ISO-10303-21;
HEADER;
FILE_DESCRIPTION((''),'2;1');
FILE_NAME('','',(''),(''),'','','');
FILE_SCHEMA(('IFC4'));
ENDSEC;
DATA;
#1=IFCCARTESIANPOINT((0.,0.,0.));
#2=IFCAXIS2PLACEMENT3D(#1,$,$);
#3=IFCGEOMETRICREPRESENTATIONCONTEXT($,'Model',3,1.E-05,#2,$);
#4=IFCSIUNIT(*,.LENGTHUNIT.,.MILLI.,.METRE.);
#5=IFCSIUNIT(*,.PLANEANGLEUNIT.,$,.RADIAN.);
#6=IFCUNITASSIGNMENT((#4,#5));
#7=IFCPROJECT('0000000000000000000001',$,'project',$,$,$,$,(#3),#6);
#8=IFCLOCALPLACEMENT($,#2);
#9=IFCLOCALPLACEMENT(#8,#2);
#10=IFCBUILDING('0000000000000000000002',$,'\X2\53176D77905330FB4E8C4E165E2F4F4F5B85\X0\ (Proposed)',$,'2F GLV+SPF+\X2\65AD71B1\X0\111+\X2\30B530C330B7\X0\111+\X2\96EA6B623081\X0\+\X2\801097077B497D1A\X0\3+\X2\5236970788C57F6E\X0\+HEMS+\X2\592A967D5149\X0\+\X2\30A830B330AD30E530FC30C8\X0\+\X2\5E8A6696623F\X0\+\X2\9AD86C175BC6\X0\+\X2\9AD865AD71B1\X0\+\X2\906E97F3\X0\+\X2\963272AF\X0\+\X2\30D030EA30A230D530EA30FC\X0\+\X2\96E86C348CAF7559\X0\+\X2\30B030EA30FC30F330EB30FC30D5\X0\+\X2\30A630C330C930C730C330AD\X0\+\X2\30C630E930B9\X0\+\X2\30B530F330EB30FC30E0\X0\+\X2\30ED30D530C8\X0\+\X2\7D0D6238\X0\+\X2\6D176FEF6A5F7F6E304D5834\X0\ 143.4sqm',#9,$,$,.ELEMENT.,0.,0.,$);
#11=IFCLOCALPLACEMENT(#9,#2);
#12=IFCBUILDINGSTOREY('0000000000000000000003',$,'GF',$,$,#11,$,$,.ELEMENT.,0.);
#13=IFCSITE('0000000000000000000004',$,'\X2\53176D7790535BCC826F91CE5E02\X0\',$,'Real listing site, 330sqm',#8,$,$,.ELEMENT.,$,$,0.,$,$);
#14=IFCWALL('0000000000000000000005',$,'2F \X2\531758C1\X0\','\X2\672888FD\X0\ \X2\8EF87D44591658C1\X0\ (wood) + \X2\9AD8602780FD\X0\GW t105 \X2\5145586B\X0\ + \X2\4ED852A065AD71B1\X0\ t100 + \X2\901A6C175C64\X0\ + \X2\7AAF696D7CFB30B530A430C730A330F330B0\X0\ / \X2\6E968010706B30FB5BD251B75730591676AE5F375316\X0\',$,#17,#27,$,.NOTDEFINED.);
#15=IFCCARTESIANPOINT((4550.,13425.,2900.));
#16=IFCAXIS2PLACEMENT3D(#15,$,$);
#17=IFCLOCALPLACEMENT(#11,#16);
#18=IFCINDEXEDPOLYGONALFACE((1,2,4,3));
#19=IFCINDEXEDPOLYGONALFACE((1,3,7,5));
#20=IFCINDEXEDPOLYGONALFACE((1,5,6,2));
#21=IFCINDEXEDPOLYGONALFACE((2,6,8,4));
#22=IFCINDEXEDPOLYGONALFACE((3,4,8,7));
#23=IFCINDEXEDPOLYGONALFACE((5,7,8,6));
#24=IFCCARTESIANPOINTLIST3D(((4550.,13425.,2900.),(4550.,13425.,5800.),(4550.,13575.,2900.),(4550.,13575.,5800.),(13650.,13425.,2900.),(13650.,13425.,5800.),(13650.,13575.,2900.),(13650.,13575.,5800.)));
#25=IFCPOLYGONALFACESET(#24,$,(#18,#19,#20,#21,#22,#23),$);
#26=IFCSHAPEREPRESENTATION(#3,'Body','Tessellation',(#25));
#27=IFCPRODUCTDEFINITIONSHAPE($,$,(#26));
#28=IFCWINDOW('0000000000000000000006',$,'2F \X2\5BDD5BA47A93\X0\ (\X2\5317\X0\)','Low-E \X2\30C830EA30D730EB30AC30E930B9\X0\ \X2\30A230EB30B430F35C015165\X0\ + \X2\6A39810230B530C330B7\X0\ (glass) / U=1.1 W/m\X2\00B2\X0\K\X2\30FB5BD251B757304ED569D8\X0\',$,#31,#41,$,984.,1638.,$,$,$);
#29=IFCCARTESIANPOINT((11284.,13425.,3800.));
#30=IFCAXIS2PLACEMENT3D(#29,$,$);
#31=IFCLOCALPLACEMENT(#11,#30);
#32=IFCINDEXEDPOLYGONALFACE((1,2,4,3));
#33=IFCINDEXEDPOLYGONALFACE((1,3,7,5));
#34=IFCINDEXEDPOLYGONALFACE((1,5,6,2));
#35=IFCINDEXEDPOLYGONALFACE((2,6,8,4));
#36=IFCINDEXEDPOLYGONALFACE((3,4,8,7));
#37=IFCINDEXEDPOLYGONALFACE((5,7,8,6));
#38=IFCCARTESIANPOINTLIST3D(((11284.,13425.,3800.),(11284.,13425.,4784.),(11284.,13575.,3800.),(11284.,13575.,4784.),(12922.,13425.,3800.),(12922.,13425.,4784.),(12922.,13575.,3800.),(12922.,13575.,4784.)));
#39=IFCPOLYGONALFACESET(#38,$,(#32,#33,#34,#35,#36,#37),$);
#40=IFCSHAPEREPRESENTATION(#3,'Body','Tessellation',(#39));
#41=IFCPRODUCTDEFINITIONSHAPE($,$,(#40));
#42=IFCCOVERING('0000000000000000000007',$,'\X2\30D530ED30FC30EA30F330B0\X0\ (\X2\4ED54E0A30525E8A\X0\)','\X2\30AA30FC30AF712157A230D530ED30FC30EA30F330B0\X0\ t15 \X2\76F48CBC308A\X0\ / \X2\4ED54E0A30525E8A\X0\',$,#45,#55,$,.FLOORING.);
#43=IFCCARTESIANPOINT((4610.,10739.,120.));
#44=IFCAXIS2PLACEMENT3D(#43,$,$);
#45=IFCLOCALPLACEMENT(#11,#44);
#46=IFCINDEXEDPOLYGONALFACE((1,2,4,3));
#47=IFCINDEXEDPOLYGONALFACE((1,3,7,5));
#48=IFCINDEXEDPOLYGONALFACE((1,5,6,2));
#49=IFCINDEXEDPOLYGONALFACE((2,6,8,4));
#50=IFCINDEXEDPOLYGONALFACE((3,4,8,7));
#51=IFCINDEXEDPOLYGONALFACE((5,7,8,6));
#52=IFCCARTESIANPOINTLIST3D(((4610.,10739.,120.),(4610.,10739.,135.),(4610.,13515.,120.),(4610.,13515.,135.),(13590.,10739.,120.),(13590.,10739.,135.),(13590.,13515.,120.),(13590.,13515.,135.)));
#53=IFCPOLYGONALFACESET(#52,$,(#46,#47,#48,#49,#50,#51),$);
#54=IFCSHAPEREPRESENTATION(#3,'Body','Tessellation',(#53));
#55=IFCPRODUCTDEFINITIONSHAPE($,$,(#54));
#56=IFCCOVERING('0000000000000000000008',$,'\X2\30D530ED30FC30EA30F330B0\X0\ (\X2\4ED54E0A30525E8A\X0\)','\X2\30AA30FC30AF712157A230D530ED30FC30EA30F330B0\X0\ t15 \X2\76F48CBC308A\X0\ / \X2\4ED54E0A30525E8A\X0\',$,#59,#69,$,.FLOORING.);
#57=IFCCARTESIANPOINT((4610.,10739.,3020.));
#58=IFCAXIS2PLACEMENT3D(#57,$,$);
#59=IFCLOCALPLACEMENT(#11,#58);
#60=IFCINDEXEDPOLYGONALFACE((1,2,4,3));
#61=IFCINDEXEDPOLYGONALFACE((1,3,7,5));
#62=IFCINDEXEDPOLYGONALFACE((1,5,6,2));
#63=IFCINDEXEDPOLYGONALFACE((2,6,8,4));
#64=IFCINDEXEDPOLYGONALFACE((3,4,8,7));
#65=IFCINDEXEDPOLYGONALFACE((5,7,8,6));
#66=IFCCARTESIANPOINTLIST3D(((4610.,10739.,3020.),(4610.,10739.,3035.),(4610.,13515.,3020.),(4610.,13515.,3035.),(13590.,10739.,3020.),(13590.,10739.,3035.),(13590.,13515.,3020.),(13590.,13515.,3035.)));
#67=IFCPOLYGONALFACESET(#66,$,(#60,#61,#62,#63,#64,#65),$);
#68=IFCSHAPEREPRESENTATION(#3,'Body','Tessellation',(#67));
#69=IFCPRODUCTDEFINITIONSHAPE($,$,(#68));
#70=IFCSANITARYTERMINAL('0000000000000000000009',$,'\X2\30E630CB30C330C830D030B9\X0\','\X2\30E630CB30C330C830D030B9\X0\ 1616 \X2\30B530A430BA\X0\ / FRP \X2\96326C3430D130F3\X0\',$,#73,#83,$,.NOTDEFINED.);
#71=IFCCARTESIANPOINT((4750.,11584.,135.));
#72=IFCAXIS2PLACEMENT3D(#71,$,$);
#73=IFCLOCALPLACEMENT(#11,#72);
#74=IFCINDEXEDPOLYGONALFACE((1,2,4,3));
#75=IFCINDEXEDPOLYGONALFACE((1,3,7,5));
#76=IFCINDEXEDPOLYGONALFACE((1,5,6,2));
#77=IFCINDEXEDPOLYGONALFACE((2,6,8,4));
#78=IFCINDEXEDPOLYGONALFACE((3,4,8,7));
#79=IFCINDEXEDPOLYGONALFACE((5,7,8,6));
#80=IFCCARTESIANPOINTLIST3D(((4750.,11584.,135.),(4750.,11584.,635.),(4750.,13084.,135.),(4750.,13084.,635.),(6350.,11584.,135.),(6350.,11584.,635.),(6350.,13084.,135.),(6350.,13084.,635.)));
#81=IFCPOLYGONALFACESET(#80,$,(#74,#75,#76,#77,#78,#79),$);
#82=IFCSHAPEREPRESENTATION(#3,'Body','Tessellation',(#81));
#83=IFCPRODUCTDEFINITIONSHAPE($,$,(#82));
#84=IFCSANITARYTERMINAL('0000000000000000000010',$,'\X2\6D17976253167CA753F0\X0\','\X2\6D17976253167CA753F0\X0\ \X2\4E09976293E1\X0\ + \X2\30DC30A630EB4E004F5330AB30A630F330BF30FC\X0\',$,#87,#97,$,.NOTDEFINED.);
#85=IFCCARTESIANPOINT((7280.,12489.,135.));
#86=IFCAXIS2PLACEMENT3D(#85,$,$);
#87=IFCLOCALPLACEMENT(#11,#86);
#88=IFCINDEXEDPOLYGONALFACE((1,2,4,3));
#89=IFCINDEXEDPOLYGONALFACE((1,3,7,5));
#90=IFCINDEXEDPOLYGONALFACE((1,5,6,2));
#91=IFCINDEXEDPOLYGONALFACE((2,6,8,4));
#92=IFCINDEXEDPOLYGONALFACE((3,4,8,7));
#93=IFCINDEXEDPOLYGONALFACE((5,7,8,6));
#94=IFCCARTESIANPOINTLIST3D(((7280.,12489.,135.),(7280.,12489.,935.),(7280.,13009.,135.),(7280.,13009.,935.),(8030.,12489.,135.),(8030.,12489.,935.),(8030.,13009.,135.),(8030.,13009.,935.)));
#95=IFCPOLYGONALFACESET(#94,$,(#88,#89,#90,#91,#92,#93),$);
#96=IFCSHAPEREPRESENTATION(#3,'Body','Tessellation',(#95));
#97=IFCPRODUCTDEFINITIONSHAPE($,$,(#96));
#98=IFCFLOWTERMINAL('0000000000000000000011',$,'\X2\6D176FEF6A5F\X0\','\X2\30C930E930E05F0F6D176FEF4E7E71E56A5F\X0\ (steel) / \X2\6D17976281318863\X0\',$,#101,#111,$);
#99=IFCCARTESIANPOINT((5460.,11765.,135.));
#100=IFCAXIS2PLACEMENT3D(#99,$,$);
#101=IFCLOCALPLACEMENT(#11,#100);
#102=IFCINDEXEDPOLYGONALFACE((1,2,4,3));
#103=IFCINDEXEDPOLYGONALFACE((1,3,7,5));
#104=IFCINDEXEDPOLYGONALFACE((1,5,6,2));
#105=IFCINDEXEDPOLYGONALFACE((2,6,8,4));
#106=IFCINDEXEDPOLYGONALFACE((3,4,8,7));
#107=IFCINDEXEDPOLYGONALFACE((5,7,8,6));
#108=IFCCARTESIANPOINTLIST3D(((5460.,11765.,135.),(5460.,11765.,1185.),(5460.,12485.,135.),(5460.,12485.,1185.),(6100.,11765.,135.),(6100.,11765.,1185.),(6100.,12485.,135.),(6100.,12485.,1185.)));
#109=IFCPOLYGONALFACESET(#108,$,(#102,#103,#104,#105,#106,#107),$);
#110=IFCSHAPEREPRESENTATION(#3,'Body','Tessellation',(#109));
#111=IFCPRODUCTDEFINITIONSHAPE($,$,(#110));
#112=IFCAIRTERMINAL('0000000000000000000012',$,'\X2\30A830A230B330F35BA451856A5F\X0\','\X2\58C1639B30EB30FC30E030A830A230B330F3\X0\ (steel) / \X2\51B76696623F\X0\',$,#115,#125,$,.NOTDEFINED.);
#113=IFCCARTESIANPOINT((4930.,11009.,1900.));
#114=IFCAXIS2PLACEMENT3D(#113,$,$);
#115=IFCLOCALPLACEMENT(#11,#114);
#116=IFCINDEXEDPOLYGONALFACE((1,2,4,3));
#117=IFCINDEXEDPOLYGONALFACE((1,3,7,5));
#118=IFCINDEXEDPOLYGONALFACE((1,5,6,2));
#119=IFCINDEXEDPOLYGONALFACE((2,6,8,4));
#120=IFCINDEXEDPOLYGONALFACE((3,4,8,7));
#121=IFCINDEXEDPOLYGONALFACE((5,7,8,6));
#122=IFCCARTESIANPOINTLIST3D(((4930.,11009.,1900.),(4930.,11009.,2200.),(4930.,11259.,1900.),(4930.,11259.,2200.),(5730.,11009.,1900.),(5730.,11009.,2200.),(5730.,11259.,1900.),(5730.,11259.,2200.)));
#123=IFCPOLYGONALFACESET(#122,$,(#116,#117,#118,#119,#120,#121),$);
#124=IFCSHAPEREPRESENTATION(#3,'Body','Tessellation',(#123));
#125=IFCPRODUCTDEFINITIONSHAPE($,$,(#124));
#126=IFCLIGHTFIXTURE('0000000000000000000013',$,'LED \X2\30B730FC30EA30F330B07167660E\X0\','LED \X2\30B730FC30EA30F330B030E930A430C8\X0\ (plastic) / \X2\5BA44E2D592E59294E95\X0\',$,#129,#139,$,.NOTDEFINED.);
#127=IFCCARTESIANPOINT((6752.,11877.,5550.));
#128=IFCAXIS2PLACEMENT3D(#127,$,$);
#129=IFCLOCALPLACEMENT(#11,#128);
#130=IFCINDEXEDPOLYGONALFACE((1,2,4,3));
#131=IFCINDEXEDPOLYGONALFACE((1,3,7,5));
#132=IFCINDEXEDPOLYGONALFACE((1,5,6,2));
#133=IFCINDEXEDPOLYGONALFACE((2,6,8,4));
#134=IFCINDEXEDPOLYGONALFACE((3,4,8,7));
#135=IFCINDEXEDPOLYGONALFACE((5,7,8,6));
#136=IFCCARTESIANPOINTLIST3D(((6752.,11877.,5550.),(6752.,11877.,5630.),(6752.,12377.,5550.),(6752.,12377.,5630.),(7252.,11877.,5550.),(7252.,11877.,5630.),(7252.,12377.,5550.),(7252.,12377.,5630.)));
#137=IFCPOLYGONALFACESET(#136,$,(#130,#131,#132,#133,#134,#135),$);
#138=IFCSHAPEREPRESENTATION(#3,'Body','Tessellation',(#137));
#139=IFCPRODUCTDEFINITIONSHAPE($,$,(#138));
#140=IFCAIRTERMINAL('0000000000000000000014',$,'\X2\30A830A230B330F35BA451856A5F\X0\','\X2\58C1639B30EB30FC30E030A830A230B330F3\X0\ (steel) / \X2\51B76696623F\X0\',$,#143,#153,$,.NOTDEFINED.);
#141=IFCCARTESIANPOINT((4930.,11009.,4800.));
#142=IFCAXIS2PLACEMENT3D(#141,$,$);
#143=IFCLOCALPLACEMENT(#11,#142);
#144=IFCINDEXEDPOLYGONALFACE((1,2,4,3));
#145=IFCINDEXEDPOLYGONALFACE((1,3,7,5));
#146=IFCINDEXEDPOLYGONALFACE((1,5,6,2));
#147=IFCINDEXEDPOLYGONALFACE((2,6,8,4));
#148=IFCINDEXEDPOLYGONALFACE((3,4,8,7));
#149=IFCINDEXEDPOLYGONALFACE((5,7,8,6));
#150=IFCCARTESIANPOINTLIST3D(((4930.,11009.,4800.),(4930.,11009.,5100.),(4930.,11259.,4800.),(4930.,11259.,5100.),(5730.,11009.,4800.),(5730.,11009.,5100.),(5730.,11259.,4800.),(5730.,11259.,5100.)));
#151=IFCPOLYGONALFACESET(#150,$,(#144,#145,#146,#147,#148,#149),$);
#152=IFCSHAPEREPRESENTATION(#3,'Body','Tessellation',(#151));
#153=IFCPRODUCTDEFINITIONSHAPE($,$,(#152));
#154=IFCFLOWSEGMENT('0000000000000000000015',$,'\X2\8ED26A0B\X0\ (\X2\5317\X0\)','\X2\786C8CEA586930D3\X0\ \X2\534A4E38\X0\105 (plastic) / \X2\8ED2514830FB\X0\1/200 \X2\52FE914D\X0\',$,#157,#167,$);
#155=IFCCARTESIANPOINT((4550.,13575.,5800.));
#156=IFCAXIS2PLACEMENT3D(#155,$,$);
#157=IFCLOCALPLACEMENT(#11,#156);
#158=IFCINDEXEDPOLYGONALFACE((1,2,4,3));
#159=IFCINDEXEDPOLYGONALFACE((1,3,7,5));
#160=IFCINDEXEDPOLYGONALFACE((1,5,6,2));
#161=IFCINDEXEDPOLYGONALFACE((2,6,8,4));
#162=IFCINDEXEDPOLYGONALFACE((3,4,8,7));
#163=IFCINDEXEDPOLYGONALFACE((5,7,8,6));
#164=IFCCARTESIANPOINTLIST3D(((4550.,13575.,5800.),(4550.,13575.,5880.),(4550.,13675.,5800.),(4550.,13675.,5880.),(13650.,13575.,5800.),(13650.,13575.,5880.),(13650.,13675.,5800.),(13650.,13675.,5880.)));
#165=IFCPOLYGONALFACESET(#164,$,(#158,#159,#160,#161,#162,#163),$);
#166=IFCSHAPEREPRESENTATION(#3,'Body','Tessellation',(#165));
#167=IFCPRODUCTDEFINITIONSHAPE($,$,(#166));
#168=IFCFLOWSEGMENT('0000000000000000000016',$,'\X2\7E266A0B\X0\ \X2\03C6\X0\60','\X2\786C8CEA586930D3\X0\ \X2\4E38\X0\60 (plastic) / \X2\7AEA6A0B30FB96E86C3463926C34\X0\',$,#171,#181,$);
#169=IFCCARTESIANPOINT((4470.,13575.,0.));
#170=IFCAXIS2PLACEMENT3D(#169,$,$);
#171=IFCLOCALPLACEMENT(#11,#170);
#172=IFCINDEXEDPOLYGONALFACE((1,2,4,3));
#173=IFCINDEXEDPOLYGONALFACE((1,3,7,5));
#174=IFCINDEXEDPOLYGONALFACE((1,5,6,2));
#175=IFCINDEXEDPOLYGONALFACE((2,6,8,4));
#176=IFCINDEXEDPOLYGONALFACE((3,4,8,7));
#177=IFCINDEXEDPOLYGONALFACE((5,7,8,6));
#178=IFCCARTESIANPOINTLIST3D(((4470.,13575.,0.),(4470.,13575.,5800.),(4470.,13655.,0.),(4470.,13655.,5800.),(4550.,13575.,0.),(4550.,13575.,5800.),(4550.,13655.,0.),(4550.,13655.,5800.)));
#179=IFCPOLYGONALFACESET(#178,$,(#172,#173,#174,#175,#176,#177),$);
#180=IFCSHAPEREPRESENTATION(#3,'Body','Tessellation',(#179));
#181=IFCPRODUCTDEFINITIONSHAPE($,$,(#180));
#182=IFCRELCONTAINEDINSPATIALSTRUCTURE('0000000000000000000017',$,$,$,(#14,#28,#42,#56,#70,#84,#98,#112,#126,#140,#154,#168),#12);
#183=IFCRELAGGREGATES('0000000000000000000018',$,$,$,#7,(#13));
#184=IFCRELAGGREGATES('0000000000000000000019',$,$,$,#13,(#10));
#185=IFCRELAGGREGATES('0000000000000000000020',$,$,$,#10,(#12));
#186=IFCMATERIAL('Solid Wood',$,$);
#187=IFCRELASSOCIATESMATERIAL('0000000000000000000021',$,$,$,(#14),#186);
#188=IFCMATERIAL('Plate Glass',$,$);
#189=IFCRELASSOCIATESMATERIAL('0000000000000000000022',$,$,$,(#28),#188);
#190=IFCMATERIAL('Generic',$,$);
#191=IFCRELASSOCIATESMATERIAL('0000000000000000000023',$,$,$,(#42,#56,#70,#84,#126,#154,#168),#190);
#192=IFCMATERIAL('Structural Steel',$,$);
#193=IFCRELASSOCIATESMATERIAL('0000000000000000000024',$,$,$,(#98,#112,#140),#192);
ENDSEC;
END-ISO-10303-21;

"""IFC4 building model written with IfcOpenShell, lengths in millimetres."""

from ifc_helpers import new_model, si_unit, frame, frame_2d, origin, place, context, project, spatial, rectangle, extrude, material, element, fill, save


model = new_model("IFC4")

# Units and contexts
model_context = context("Model", 3, precision=1e-05, world=origin())
ifc_project = project(units=[si_unit("LENGTHUNIT", "METRE", prefix="MILLI"), si_unit("PLANEANGLEUNIT", "RADIAN")], contexts=[model_context])

# Site, building, storey
site_placement = place(None, origin())
site = spatial("IfcSite", under=ifc_project, at=site_placement, Name="北海道富良野市", ObjectType="Real listing site, 330sqm", CompositionType="ELEMENT", RefElevation=0.0)
building_placement = place(site_placement, origin())
building = spatial("IfcBuilding", under=site, at=building_placement, Name="北海道・二世帯住宅 (Proposed)", ObjectType="2F GLV+SPF+断熱111+サッシ111+雪止め+耐震等級3+制震装置+HEMS+太陽光+エコキュート+床暖房+高気密+高断熱+遮音+防犯+バリアフリー+雨水貯留+グリーンルーフ+ウッドデッキ+テラス+サンルーム+ロフト+納戸+洗濯機置き場 143.4sqm", CompositionType="ELEMENT", ElevationOfRefHeight=0.0, ElevationOfTerrain=0.0)
storey_placement = place(building_placement, origin())
storey = spatial("IfcBuildingStorey", under=building, at=storey_placement, Name="GF", CompositionType="ELEMENT", Elevation=0.0)

# Shared definitions
ifc_material_1 = material(Name="Solid Wood")

# Shared definitions
ifc_material_2 = material(Name="Plate Glass")

# Wall, opening, window
wall_1_placement = place(storey_placement, frame((4550.0, 13425.0, 2900.0)))
wall_1 = element("IfcWall", 1, at=wall_1_placement, inside=storey, material=ifc_material_1, Name="2F 北壁", Description="木製 軸組外壁 (wood) + 高性能GW t105 充填 + 付加断熱 t100 + 通気層 + 窯業系サイディング / 準耐火・寒冷地外皮強化", PredefinedType="NOTDEFINED", context=model_context, shape_type="SweptSolid", body=[
    extrude(rectangle(XDim=9100.0, YDim=150.0, at=frame_2d((4550.0, 75.0))), frame((4550.0, 13425.0, 2900.0)), (0.0, 0.0, 1.0), 2900.0),
])
opening_1_placement = place(storey_placement, frame((11284.0, 13425.0, 3800.0)))
opening_1 = element("IfcOpeningElement", 2, at=opening_1_placement, cuts=wall_1, PredefinedType="NOTDEFINED", context=model_context, shape_type="SweptSolid", body=[
    extrude(rectangle(XDim=1638.0, YDim=150.0, at=frame_2d((819.0, 75.0))), frame((11284.0, 13425.0, 3800.0)), (0.0, 0.0, 1.0), 984.0),
])
window_1_placement = place(storey_placement, frame((11284.0, 13425.0, 3800.0)))
window_1 = element("IfcWindow", 3, at=window_1_placement, inside=storey, material=ifc_material_2, Name="2F 寝室窓 (北)", Description="Low-E トリプルガラス アルゴン封入 + 樹脂サッシ (glass) / U=1.1 W/m²K・寒冷地仕様", OverallHeight=984.0, OverallWidth=1638.0, context=model_context, shape_type="SweptSolid", body=[
    extrude(rectangle(XDim=1638.0, YDim=150.0, at=frame_2d((819.0, 75.0))), frame((11284.0, 13425.0, 3800.0)), (0.0, 0.0, 1.0), 984.0),
])
fill(opening_1, window_1)

# Coverings
ifc_material_3 = material(Name="Generic")
covering_1_placement = place(storey_placement, frame((4610.0, 10739.0, 120.0)))
element("IfcCovering", 4, at=covering_1_placement, inside=storey, material=ifc_material_3, Name="フローリング (仕上げ床)", Description="オーク無垢フローリング t15 直貼り / 仕上げ床", PredefinedType="FLOORING", context=model_context, shape_type="SweptSolid", body=[
    extrude(rectangle(XDim=8980.0, YDim=2776.0, at=frame_2d((4490.0, 1388.0))), frame((4610.0, 10739.0, 120.0)), (0.0, 0.0, 1.0), 15.0),
])
covering_2_placement = place(storey_placement, frame((4610.0, 10739.0, 3020.0)))
element("IfcCovering", 5, at=covering_2_placement, inside=storey, material=ifc_material_3, Name="フローリング (仕上げ床)", Description="オーク無垢フローリング t15 直貼り / 仕上げ床", PredefinedType="FLOORING", context=model_context, shape_type="SweptSolid", body=[
    extrude(rectangle(XDim=8980.0, YDim=2776.0, at=frame_2d((4490.0, 1388.0))), frame((4610.0, 10739.0, 3020.0)), (0.0, 0.0, 1.0), 15.0),
])

# Sanitary terminals
sanitary_terminal_1_placement = place(storey_placement, frame((4750.0, 11584.0, 135.0)))
element("IfcSanitaryTerminal", 6, at=sanitary_terminal_1_placement, inside=storey, material=ifc_material_3, Name="ユニットバス", Description="ユニットバス 1616 サイズ / FRP 防水パン", PredefinedType="NOTDEFINED", context=model_context, shape_type="SweptSolid", body=[
    extrude(rectangle(XDim=1600.0, YDim=1500.0, at=frame_2d((800.0, 750.0))), frame((4750.0, 11584.0, 135.0)), (0.0, 0.0, 1.0), 500.0),
])
sanitary_terminal_2_placement = place(storey_placement, frame((7280.0, 12489.0, 135.0)))
element("IfcSanitaryTerminal", 7, at=sanitary_terminal_2_placement, inside=storey, material=ifc_material_3, Name="洗面化粧台", Description="洗面化粧台 三面鏡 + ボウル一体カウンター", PredefinedType="NOTDEFINED", context=model_context, shape_type="SweptSolid", body=[
    extrude(rectangle(XDim=750.0, YDim=520.0, at=frame_2d((375.0, 260.0))), frame((7280.0, 12489.0, 135.0)), (0.0, 0.0, 1.0), 800.0),
])

# Flow terminal
ifc_material_4 = material(Name="Structural Steel")
flow_terminal_placement = place(storey_placement, frame((5460.0, 11765.0, 135.0)))
element("IfcFlowTerminal", 8, at=flow_terminal_placement, inside=storey, material=ifc_material_4, Name="洗濯機", Description="ドラム式洗濯乾燥機 (steel) / 洗面脱衣", context=model_context, shape_type="SweptSolid", body=[
    extrude(rectangle(XDim=640.0, YDim=720.0, at=frame_2d((320.0, 360.0))), frame((5460.0, 11765.0, 135.0)), (0.0, 0.0, 1.0), 1050.0),
])

# Air terminal
air_terminal_1_placement = place(storey_placement, frame((4930.0, 11009.0, 1900.0)))
element("IfcAirTerminal", 9, at=air_terminal_1_placement, inside=storey, material=ifc_material_4, Name="エアコン室内機", Description="壁掛ルームエアコン (steel) / 冷暖房", PredefinedType="NOTDEFINED", context=model_context, shape_type="SweptSolid", body=[
    extrude(rectangle(XDim=800.0, YDim=250.0, at=frame_2d((400.0, 125.0))), frame((4930.0, 11009.0, 1900.0)), (0.0, 0.0, 1.0), 300.0),
])

# Light fixture
light_fixture_placement = place(storey_placement, frame((6752.0, 11877.0, 5550.0)))
element("IfcLightFixture", 10, at=light_fixture_placement, inside=storey, material=ifc_material_3, Name="LED シーリング照明", Description="LED シーリングライト (plastic) / 室中央天井", PredefinedType="NOTDEFINED", context=model_context, shape_type="SweptSolid", body=[
    extrude(rectangle(XDim=500.0, YDim=500.0, at=frame_2d((250.0, 250.0))), frame((6752.0, 11877.0, 5550.0)), (0.0, 0.0, 1.0), 80.0),
])

# Air terminal
air_terminal_2_placement = place(storey_placement, frame((4930.0, 11009.0, 4800.0)))
element("IfcAirTerminal", 11, at=air_terminal_2_placement, inside=storey, material=ifc_material_4, Name="エアコン室内機", Description="壁掛ルームエアコン (steel) / 冷暖房", PredefinedType="NOTDEFINED", context=model_context, shape_type="SweptSolid", body=[
    extrude(rectangle(XDim=800.0, YDim=250.0, at=frame_2d((400.0, 125.0))), frame((4930.0, 11009.0, 4800.0)), (0.0, 0.0, 1.0), 300.0),
])

# Flow segments
flow_segment_1_placement = place(storey_placement, frame((4550.0, 13575.0, 5800.0)))
element("IfcFlowSegment", 12, at=flow_segment_1_placement, inside=storey, material=ifc_material_3, Name="軒樋 (北)", Description="硬質塩ビ 半丸105 (plastic) / 軒先・1/200 勾配", context=model_context, shape_type="SweptSolid", body=[
    extrude(rectangle(XDim=9100.0, YDim=100.0, at=frame_2d((4550.0, 50.0))), frame((4550.0, 13575.0, 5800.0)), (0.0, 0.0, 1.0), 80.0),
])
flow_segment_2_placement = place(storey_placement, frame((4470.0, 13575.0, 0.0)))
element("IfcFlowSegment", 13, at=flow_segment_2_placement, inside=storey, material=ifc_material_3, Name="縦樋 φ60", Description="硬質塩ビ 丸60 (plastic) / 竪樋・雨水排水", context=model_context, shape_type="SweptSolid", body=[
    extrude(rectangle(XDim=80.0, YDim=80.0, at=frame_2d((40.0, 40.0))), frame((4470.0, 13575.0, 0.0)), (0.0, 0.0, 1.0), 5800.0),
])

save(model, "model.ifc")
